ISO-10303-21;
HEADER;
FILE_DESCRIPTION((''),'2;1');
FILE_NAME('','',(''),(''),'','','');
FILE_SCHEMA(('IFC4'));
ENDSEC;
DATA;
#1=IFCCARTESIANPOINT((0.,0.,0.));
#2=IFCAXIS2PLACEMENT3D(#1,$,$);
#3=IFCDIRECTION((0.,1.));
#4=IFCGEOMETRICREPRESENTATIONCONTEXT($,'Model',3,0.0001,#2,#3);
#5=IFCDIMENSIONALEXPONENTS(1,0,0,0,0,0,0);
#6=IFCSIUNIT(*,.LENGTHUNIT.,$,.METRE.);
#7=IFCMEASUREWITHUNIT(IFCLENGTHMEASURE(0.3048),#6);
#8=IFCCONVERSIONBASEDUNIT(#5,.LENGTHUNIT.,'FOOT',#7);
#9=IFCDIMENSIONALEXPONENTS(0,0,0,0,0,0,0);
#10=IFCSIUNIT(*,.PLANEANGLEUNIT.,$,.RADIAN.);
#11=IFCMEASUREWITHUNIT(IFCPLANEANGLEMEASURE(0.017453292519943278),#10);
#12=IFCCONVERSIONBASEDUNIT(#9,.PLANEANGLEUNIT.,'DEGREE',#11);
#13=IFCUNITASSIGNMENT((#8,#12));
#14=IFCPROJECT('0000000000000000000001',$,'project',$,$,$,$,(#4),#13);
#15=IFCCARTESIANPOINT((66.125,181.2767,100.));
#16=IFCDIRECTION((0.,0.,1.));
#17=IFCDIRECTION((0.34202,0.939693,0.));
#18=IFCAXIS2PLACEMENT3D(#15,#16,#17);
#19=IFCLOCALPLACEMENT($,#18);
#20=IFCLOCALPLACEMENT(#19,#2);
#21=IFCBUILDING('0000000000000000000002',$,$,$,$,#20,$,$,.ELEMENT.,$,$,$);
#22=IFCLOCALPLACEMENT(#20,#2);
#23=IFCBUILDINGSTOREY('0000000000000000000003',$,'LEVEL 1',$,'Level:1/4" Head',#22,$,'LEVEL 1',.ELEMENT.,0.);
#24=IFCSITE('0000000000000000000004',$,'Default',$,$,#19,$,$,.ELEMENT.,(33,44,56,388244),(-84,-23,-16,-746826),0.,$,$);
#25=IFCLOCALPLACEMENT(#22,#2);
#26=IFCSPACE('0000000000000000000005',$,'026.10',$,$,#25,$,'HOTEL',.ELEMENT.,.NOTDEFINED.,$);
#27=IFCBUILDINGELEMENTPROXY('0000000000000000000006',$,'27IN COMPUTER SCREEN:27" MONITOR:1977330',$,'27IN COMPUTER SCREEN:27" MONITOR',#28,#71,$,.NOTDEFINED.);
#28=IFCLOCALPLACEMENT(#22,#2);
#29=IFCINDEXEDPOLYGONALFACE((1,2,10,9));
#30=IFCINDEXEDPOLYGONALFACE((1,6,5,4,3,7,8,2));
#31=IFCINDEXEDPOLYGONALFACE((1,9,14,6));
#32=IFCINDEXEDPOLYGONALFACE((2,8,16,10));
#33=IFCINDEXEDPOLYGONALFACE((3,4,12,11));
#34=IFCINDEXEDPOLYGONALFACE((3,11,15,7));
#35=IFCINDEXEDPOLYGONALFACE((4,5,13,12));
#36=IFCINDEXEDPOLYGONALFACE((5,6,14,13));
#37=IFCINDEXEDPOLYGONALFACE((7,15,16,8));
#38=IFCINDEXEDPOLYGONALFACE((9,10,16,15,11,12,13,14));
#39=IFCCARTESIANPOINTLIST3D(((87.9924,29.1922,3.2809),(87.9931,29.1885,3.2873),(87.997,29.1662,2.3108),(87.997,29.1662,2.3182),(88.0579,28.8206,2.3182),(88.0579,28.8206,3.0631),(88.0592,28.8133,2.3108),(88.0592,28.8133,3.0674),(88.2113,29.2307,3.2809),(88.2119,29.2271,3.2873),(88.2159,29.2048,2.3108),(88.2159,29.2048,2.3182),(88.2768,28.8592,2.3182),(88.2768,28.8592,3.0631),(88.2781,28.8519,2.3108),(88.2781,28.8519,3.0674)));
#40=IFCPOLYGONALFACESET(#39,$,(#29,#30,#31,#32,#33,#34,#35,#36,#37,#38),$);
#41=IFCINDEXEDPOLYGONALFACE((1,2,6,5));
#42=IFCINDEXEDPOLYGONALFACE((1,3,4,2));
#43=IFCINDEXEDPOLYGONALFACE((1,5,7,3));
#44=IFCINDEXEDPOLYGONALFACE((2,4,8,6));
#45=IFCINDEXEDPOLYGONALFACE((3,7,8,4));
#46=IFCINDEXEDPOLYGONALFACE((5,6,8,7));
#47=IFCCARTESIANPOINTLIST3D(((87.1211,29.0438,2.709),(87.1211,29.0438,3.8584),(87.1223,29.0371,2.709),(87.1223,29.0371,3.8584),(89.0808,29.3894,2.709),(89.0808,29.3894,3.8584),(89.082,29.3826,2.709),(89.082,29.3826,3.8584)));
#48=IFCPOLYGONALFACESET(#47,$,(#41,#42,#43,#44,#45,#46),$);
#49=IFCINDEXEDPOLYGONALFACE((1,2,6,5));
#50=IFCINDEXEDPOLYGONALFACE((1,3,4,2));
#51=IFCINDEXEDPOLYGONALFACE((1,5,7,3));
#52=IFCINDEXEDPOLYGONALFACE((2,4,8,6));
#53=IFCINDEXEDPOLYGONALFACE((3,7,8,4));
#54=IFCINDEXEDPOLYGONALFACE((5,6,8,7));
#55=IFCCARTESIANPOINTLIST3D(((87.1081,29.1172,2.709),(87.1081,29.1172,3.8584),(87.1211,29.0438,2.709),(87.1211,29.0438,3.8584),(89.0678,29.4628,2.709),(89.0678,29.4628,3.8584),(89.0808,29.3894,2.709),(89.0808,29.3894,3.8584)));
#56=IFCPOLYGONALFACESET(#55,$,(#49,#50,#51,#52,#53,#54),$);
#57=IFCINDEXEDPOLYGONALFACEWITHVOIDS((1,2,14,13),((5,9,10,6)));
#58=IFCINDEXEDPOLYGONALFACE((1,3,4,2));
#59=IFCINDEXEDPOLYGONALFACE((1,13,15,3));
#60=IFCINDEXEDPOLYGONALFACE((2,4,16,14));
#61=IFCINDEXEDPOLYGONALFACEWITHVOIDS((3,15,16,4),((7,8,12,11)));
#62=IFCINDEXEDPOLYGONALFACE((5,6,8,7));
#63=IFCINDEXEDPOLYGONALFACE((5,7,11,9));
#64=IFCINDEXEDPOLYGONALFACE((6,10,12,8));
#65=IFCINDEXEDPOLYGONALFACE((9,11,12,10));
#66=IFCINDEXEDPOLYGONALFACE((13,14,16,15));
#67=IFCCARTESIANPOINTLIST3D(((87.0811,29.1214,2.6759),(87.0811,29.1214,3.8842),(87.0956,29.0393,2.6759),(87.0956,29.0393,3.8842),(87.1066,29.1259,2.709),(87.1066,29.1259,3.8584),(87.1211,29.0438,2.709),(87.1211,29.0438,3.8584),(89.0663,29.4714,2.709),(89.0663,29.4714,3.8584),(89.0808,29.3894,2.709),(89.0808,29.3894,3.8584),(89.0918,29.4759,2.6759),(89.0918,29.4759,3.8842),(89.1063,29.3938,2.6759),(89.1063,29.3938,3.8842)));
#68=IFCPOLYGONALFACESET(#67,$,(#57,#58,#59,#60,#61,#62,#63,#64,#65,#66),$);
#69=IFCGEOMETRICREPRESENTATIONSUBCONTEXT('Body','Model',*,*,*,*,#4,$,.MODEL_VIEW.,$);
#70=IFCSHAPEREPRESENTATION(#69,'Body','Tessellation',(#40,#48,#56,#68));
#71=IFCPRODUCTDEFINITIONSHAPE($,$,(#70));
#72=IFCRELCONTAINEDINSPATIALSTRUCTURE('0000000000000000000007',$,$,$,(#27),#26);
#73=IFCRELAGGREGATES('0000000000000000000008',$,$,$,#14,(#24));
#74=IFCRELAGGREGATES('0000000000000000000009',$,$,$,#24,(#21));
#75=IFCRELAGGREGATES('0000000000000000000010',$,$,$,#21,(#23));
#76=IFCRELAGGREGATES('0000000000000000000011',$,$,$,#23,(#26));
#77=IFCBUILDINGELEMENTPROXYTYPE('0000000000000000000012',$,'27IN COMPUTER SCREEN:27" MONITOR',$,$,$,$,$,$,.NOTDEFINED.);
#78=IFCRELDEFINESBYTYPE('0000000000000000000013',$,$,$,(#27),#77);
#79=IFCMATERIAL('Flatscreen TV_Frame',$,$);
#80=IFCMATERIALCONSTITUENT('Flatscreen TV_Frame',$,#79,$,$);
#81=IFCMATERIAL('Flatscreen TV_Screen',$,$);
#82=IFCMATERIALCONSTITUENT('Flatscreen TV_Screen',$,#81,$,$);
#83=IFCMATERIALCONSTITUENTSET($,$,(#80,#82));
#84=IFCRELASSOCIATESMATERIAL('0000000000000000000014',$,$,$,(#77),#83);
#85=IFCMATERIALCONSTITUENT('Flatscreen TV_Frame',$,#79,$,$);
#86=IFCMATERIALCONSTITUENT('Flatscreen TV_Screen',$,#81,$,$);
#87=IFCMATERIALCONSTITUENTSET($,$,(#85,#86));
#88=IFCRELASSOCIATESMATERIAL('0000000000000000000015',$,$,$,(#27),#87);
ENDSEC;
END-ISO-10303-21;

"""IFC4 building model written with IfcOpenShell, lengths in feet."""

from ifc_helpers import new_model, entity, si_unit, converted_unit, direction, frame, frame_2d, origin, origin_2d_with_axis, place, context, subcontext, project, spatial, polyline, rectangle, outline, extrude, source, transform, mapped, material, constituent, constituent_set, type_object, type_shapes, element, save


model = new_model("IFC4")

# Units and contexts
model_context = context("Model", 3, precision=0.0001, world=origin(), true_north=direction((0.0, 1.0)))
body_context = subcontext(model_context, "Body", "Model", "MODEL_VIEW")
ifc_project = project(units=[converted_unit("LENGTHUNIT", "FOOT", entity("IfcLengthMeasure", 0.3048), si_unit("LENGTHUNIT", "METRE"), dimensions=[1, 0, 0, 0, 0, 0, 0]), converted_unit("PLANEANGLEUNIT", "DEGREE", entity("IfcPlaneAngleMeasure", 0.017453292519943278), si_unit("PLANEANGLEUNIT", "RADIAN"), dimensions=[0, 0, 0, 0, 0, 0, 0])], contexts=[model_context])

# Site, building, storey
site_placement = place(None, frame((66.125, 181.2767, 100.0), z_axis=(0.0, 0.0, 1.0), x_axis=(0.34202, 0.939693, 0.0)))
site = spatial("IfcSite", under=ifc_project, at=site_placement, Name="Default", CompositionType="ELEMENT", RefLatitude=(33, 44, 56, 388244), RefLongitude=(-84, -23, -16, -746826), RefElevation=0.0)
building_placement = place(site_placement, origin())
building = spatial("IfcBuilding", under=site, at=building_placement, CompositionType="ELEMENT")
storey_placement = place(building_placement, origin())
storey = spatial("IfcBuildingStorey", under=building, at=storey_placement, Name="LEVEL 1", ObjectType="Level:1/4\" Head", LongName="LEVEL 1", CompositionType="ELEMENT", Elevation=0.0)

# Shared definitions
space_1_placement = place(storey_placement, origin())
space_1 = spatial("IfcSpace", under=storey, at=space_1_placement, Name="026.10", LongName="HOTEL", CompositionType="ELEMENT", PredefinedType="NOTDEFINED")

# Building element proxy
ifc_material_1 = material(Name="Flatscreen TV_Frame")
ifc_material_2 = material(Name="Flatscreen TV_Screen")
ifc_constituent_1 = constituent(ifc_material_1, Name="Flatscreen TV_Frame")
ifc_constituent_2 = constituent(ifc_material_2, Name="Flatscreen TV_Screen")
ifc_constituent_set_1 = constituent_set(constituents=[ifc_constituent_1, ifc_constituent_2])
ifc_constituent_3 = constituent(ifc_material_1, Name="Flatscreen TV_Frame")
ifc_constituent_4 = constituent(ifc_material_2, Name="Flatscreen TV_Screen")
ifc_constituent_set_2 = constituent_set(constituents=[ifc_constituent_3, ifc_constituent_4])
building_element_proxy_type_1 = type_object("IfcBuildingElementProxyType", Name="27IN COMPUTER SCREEN:27\" MONITOR", PredefinedType="NOTDEFINED", material=ifc_constituent_set_2)
shared_shape_1 = source(origin(), body_context, "Body", "SweptSolid", [
    extrude(outline(polyline([(0.3657, -0.4392), (0.3731, -0.4392), (0.3731, 0.0007), (-0.2821, 0.379), (-0.4613, 0.0686), (-0.4548, 0.0649), (-0.2794, 0.3688), (0.3657, -0.0036), (0.3657, -0.4392)])), frame((-0.1111, 0.0264, 0.0687), z_axis=(1.0, 0.0, 0.0), x_axis=(0.0, -0.5, 0.866025)), (0.0, 0.0, 1.0), 0.2222),
    extrude(rectangle(XDim=1.9899, YDim=0.0068, at=origin_2d_with_axis()), frame((0.0, 0.2257, 0.0331), z_axis=(0.0, 0.0, 1.0), x_axis=(-1.0, 0.0, 0.0)), (0.0, 0.0, 1.0), 1.1493),
    extrude(rectangle(XDim=1.9899, YDim=0.0746, at=frame_2d((0.0, 0.0), x_axis=(1.0, 0.0))), frame((0.0, 0.2664, 0.0331), z_axis=(0.0, 0.0, 1.0), x_axis=(-1.0, 0.0, 0.0)), (0.0, 0.0, 1.0), 1.1493),
    extrude(outline(polyline([(-0.6042, -1.0208), (0.6042, -1.0208), (0.6042, 1.0208), (-0.6042, 1.0208), (-0.6042, -1.0208)]), holes=[polyline([(-0.5783, -0.995), (-0.5783, 0.995), (0.571, 0.995), (0.571, -0.995), (-0.5783, -0.995)])]), frame((0.0, 0.2292, 0.6042), z_axis=(0.0, 1.0, 0.0), x_axis=(0.0, 0.0, -1.0)), (0.0, 0.0, 1.0), 0.0833),
])
type_shapes(building_element_proxy_type_1, [shared_shape_1])
proxy_1_placement = place(space_1_placement, frame((88.1407, 28.9909, 2.6759), z_axis=(0.0, 0.0, 1.0), x_axis=(0.984808, 0.173648, 0.0)))
element("IfcBuildingElementProxy", 1, at=proxy_1_placement, inside=space_1, type_object=building_element_proxy_type_1, material=ifc_constituent_set_1, Name="27IN COMPUTER SCREEN:27\" MONITOR:1977330", ObjectType="27IN COMPUTER SCREEN:27\" MONITOR", PredefinedType="NOTDEFINED", context=body_context, shape_type="MappedRepresentation", body=[
    mapped(shared_shape_1, transform((0.0, 0.0, 0.0), scale=1.0)),
])

save(model, "model.ifc")
